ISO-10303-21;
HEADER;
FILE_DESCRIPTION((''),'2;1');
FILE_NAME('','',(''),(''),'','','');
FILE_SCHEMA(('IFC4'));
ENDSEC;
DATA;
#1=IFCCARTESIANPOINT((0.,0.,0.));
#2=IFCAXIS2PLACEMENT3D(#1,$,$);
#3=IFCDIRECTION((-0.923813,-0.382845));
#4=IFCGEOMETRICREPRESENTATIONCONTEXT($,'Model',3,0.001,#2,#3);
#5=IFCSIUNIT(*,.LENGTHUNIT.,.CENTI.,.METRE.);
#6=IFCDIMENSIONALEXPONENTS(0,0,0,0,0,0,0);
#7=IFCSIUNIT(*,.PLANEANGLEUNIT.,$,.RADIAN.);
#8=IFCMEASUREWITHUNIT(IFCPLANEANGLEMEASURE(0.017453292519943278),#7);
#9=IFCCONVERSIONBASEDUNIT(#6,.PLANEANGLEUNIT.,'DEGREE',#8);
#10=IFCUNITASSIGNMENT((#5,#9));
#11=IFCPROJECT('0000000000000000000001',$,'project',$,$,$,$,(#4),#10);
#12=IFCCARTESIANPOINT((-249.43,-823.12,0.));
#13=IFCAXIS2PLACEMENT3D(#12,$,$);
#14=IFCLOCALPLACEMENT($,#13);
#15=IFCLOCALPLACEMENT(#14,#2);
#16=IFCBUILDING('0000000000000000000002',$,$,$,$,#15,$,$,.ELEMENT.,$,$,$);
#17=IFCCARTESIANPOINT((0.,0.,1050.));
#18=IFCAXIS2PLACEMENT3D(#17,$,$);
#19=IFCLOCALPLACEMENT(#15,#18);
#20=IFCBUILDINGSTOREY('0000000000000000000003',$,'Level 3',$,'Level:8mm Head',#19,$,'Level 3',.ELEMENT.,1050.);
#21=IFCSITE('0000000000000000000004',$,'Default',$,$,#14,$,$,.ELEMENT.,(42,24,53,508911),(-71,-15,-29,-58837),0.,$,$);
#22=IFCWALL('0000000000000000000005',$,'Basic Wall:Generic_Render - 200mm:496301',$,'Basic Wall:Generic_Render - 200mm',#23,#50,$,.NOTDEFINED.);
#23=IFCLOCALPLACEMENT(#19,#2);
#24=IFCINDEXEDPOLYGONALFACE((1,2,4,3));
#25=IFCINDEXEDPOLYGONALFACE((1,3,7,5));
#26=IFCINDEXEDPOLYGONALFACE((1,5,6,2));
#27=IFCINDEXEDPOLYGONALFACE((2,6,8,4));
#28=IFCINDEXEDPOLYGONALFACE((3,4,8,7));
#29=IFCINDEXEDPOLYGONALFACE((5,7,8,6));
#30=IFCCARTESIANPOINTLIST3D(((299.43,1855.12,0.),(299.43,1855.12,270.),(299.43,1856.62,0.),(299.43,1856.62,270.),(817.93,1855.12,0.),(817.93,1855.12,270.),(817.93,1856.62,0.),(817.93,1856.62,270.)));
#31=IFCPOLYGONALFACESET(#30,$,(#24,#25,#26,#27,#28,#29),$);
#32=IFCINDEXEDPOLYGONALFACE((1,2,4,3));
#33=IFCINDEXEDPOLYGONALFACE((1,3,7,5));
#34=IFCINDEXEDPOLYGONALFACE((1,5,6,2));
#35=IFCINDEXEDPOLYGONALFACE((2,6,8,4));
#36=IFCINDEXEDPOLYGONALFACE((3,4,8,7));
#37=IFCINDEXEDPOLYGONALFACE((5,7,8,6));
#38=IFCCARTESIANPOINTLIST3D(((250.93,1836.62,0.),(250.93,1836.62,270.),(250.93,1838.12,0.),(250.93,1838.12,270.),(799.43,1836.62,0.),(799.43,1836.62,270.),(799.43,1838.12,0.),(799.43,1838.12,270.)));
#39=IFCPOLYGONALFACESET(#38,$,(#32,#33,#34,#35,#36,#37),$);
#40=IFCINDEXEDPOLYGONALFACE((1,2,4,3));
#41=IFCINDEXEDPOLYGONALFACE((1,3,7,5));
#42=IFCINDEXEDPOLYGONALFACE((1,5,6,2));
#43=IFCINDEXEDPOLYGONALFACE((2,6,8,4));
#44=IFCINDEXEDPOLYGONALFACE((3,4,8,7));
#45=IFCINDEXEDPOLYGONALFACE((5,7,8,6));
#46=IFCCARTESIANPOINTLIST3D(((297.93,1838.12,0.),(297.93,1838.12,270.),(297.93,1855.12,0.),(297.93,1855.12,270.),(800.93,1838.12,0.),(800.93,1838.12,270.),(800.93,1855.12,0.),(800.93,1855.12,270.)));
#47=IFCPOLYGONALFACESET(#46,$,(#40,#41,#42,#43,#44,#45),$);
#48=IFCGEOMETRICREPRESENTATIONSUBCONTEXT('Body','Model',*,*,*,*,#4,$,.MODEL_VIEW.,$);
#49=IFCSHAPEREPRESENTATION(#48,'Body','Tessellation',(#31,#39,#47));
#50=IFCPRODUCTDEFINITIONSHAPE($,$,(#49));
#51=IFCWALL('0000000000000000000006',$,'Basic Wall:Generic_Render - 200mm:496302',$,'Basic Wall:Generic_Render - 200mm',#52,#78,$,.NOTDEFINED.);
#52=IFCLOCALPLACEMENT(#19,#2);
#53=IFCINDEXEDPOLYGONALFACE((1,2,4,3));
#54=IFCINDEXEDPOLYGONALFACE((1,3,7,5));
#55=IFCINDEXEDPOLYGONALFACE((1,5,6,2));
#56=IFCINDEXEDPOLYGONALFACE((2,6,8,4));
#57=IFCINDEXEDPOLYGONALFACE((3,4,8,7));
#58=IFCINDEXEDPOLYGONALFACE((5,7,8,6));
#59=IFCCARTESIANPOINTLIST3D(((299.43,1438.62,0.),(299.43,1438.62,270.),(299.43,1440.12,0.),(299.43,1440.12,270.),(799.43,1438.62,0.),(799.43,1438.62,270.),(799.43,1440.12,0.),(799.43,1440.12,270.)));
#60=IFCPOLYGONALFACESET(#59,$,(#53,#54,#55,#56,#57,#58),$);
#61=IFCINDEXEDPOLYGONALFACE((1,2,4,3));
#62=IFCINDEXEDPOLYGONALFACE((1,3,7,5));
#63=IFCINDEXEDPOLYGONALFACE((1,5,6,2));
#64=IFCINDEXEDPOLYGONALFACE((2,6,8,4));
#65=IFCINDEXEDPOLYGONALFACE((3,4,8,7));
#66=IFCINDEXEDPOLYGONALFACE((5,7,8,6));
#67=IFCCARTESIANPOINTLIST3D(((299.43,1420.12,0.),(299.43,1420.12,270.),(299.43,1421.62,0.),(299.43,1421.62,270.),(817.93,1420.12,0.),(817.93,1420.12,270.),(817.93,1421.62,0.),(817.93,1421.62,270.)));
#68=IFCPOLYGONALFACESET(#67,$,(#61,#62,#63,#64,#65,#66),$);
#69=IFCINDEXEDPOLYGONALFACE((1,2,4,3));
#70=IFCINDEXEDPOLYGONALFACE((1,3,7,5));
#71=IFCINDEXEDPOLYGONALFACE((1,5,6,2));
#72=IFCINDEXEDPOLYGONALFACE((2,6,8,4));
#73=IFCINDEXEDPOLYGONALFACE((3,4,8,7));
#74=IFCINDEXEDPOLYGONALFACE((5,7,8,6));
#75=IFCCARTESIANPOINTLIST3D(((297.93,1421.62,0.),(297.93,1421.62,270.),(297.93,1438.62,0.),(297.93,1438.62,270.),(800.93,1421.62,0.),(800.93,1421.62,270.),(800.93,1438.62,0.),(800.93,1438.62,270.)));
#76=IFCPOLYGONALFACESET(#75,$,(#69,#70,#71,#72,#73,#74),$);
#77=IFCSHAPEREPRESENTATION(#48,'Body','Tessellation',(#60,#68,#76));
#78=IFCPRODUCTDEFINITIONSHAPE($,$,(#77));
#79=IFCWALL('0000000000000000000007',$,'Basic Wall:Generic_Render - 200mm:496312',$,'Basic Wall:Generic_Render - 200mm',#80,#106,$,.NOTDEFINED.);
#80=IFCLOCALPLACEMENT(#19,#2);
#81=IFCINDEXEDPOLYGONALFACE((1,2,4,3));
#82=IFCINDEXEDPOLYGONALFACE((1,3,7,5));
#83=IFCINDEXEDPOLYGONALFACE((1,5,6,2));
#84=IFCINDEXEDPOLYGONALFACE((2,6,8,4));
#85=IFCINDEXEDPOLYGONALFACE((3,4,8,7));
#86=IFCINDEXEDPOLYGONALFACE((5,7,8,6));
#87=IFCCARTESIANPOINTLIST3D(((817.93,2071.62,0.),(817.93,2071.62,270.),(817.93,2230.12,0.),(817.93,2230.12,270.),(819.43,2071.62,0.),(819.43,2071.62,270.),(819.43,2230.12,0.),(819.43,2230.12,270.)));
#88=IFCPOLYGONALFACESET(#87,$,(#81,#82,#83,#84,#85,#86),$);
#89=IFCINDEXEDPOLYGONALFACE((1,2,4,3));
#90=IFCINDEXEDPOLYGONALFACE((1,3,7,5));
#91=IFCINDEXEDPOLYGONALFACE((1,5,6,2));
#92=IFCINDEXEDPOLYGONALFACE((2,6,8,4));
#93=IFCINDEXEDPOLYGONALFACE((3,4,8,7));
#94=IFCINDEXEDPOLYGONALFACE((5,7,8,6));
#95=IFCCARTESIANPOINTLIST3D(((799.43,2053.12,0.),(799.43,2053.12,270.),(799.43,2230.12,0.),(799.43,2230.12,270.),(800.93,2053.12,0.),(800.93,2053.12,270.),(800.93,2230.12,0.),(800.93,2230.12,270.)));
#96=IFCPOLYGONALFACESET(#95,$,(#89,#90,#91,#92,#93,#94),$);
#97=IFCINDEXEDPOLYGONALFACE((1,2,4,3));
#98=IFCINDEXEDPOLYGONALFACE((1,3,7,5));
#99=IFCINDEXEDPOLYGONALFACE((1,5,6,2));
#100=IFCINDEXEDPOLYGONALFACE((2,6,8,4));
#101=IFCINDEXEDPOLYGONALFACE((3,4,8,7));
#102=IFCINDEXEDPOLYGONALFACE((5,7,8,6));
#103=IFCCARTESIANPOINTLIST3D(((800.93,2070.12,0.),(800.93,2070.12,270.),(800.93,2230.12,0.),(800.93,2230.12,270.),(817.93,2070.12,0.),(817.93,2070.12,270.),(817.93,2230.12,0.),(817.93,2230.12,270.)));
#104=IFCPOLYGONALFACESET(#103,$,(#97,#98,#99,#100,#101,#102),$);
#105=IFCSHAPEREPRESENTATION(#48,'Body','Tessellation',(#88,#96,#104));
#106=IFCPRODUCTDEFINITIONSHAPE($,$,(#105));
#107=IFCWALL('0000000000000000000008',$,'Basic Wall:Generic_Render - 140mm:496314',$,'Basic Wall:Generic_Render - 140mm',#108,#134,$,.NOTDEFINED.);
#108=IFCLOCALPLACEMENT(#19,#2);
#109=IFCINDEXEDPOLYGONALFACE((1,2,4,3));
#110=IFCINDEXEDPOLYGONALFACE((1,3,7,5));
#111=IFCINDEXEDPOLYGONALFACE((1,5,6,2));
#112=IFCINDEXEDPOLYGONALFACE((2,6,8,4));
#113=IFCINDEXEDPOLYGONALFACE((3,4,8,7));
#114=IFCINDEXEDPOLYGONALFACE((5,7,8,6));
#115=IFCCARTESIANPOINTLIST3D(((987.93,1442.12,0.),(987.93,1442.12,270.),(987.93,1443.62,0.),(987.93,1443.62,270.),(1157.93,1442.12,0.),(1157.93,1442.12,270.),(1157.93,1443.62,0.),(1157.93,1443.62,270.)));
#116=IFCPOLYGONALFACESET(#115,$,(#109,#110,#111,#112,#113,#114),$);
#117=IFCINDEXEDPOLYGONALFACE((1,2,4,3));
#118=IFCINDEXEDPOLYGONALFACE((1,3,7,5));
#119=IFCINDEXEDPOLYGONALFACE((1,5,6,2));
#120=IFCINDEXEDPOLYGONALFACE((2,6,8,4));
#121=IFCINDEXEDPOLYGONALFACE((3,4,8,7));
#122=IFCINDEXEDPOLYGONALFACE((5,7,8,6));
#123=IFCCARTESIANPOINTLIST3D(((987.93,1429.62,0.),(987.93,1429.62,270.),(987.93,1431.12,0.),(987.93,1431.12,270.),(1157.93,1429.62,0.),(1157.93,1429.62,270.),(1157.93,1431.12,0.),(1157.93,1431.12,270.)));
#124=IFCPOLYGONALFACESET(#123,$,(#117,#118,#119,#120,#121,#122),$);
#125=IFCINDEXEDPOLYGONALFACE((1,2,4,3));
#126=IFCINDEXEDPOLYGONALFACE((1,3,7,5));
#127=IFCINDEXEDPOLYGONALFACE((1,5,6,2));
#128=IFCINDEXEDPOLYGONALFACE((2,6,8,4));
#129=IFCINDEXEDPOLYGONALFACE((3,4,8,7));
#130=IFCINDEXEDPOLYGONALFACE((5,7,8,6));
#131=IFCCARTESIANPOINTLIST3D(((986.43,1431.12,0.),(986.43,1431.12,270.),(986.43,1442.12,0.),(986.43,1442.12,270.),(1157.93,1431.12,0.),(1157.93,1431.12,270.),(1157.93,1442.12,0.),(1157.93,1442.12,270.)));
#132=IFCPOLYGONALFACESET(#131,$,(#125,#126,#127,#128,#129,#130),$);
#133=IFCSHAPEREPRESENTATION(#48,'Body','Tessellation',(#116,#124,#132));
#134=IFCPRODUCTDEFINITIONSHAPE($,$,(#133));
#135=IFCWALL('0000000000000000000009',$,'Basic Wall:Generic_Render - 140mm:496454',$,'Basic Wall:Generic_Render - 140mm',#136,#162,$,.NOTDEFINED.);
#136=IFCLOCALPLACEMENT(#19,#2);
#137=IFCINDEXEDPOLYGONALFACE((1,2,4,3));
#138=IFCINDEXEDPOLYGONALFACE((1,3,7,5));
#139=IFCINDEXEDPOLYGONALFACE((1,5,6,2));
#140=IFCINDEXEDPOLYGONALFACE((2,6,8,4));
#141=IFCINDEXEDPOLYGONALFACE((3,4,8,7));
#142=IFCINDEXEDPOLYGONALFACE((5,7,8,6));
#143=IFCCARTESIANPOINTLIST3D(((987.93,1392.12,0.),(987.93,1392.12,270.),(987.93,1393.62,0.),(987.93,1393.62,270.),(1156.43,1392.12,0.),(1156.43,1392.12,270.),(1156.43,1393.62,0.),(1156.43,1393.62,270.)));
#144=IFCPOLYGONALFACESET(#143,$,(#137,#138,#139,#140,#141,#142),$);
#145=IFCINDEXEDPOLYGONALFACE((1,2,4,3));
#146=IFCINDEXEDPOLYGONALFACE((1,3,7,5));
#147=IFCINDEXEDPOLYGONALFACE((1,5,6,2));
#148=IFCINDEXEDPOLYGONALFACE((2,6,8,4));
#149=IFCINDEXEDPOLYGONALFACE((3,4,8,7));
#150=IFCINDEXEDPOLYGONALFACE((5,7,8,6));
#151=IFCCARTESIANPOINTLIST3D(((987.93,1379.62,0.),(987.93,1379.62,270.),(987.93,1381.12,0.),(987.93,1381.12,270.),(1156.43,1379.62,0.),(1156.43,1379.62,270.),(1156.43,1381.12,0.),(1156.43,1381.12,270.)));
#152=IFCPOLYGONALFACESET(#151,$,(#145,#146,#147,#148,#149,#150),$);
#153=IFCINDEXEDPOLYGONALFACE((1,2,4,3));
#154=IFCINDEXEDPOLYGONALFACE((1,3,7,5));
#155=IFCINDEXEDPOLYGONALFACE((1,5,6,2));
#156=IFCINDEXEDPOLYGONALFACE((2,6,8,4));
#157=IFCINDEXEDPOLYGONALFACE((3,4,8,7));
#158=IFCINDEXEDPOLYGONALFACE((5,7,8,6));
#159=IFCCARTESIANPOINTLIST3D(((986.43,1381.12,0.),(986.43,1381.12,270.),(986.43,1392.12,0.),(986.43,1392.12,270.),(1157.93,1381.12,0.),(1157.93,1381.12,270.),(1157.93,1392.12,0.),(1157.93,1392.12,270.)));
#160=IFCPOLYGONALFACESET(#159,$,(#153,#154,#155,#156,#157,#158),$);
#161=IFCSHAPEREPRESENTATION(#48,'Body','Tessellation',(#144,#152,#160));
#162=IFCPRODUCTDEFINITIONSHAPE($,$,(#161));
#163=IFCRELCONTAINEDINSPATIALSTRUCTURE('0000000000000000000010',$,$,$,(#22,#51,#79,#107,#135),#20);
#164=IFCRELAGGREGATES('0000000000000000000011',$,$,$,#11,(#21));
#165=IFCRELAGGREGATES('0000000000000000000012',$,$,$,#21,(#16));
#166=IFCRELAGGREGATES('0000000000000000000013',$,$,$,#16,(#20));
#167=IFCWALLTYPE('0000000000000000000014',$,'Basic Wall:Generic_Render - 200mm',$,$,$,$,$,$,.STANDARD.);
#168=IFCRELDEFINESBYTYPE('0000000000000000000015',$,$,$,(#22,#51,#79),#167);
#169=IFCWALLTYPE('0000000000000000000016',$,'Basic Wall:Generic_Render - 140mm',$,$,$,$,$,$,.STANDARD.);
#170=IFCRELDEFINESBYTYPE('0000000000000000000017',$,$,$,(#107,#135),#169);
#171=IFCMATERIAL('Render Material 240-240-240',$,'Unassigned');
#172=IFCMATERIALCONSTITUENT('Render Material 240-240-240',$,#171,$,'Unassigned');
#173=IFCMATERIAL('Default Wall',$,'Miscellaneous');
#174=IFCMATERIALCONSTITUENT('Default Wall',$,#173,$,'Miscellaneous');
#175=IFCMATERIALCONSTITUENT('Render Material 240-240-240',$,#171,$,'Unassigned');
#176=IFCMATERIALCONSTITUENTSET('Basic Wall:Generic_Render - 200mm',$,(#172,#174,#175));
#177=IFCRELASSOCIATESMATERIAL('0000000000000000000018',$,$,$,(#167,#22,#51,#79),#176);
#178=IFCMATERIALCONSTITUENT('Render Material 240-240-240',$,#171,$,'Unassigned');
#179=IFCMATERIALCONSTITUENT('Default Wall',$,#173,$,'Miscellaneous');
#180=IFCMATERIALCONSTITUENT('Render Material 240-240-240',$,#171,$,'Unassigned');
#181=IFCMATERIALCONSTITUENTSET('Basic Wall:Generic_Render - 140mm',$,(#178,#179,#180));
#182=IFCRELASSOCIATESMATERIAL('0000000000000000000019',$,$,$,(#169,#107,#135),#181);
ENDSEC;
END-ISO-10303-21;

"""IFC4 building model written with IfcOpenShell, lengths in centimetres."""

from ifc_helpers import new_model, entity, si_unit, converted_unit, direction, frame, origin, place, context, subcontext, project, spatial, indexed_curve, outline, extrude, material, constituent, constituent_set, type_object, element, save


model = new_model("IFC4")

# Units and contexts
model_context = context("Model", 3, precision=0.001, world=origin(), true_north=direction((-0.923813, -0.382845)))
body_context = subcontext(model_context, "Body", "Model", "MODEL_VIEW")
ifc_project = project(units=[si_unit("LENGTHUNIT", "METRE", prefix="CENTI"), converted_unit("PLANEANGLEUNIT", "DEGREE", entity("IfcPlaneAngleMeasure", 0.017453292519943278), si_unit("PLANEANGLEUNIT", "RADIAN"), dimensions=[0, 0, 0, 0, 0, 0, 0])], contexts=[model_context])

# Site, building, storey
site_placement = place(None, frame((-249.43, -823.12, 0.0)))
site = spatial("IfcSite", under=ifc_project, at=site_placement, Name="Default", CompositionType="ELEMENT", RefLatitude=(42, 24, 53, 508911), RefLongitude=(-71, -15, -29, -58837), RefElevation=0.0)
building_placement = place(site_placement, origin())
building = spatial("IfcBuilding", under=site, at=building_placement, CompositionType="ELEMENT")
storey_placement = place(building_placement, frame((0.0, 0.0, 1050.0)))
storey = spatial("IfcBuildingStorey", under=building, at=storey_placement, Name="Level 3", ObjectType="Level:8mm Head", LongName="Level 3", CompositionType="ELEMENT", Elevation=1050.0)

# Shared definitions
ifc_material_1 = material(Name="Render Material 240-240-240", Category="Unassigned")

# Shared definitions
ifc_constituent_1 = constituent(ifc_material_1, Name="Render Material 240-240-240", Category="Unassigned")
ifc_material_2 = material(Name="Default Wall", Category="Miscellaneous")
ifc_constituent_2 = constituent(ifc_material_2, Name="Default Wall", Category="Miscellaneous")
ifc_constituent_3 = constituent(ifc_material_1, Name="Render Material 240-240-240", Category="Unassigned")
ifc_constituent_set_1 = constituent_set(constituents=[ifc_constituent_1, ifc_constituent_2, ifc_constituent_3], Name="Basic Wall:Generic_Render - 200mm")
wall_type_1 = type_object("IfcWallType", Name="Basic Wall:Generic_Render - 200mm", PredefinedType="STANDARD", material=ifc_constituent_set_1)

# Walls
wall_1_placement = place(storey_placement, frame((799.43, 1846.62, 0.0), z_axis=(0.0, 0.0, 1.0), x_axis=(-1.0, 0.0, 0.0)))
element("IfcWall", 1, at=wall_1_placement, inside=storey, type_object=wall_type_1, material=ifc_constituent_set_1, Name="Basic Wall:Generic_Render - 200mm:496301", ObjectType="Basic Wall:Generic_Render - 200mm", PredefinedType="NOTDEFINED", context=body_context, shape_type="SweptSolid", body=[
    extrude(outline(indexed_curve([(-0.75, -259.25), (0.75, -259.25), (0.75, 259.25), (-0.75, 259.25), (-0.75, -259.25)], self_intersect=False)), frame((240.75, -9.25, 0.0), z_axis=(0.0, 0.0, 1.0), x_axis=(0.0, 1.0, 0.0)), (0.0, 0.0, 1.0), 270.0),
    extrude(outline(indexed_curve([(-0.75, -274.25), (0.75, -274.25), (0.75, 274.25), (-0.75, 274.25), (-0.75, -274.25)], self_intersect=False)), frame((274.25, 9.25, 0.0), z_axis=(0.0, 0.0, 1.0), x_axis=(0.0, -1.0, 0.0)), (0.0, 0.0, 1.0), 270.0),
    extrude(outline(indexed_curve([(-251.5, -8.5), (251.5, -8.5), (251.5, 8.5), (-251.5, 8.5), (-251.5, -8.5)], self_intersect=False)), frame((250.0, 0.0, 0.0)), (0.0, 0.0, 1.0), 270.0),
])
wall_2_placement = place(storey_placement, frame((799.43, 1430.12, 0.0), z_axis=(0.0, 0.0, 1.0), x_axis=(-1.0, 0.0, 0.0)))
element("IfcWall", 2, at=wall_2_placement, inside=storey, type_object=wall_type_1, material=ifc_constituent_set_1, Name="Basic Wall:Generic_Render - 200mm:496302", ObjectType="Basic Wall:Generic_Render - 200mm", PredefinedType="NOTDEFINED", context=body_context, shape_type="SweptSolid", body=[
    extrude(outline(indexed_curve([(-0.75, -250.0), (0.75, -250.0), (0.75, 250.0), (-0.75, 250.0), (-0.75, -250.0)], self_intersect=False)), frame((250.0, -9.25, 0.0), z_axis=(0.0, 0.0, 1.0), x_axis=(0.0, 1.0, 0.0)), (0.0, 0.0, 1.0), 270.0),
    extrude(outline(indexed_curve([(-0.75, -259.25), (0.75, -259.25), (0.75, 259.25), (-0.75, 259.25), (-0.75, -259.25)], self_intersect=False)), frame((240.75, 9.25, 0.0), z_axis=(0.0, 0.0, 1.0), x_axis=(0.0, -1.0, 0.0)), (0.0, 0.0, 1.0), 270.0),
    extrude(outline(indexed_curve([(-251.5, -8.5), (251.5, -8.5), (251.5, 8.5), (-251.5, 8.5), (-251.5, -8.5)], self_intersect=False)), frame((250.0, 0.0, 0.0)), (0.0, 0.0, 1.0), 270.0),
])

# Walls
wall_3_placement = place(storey_placement, frame((809.43, 2071.62, 0.0), z_axis=(0.0, 0.0, 1.0), x_axis=(0.0, 1.0, 0.0)))
element("IfcWall", 3, at=wall_3_placement, inside=storey, type_object=wall_type_1, material=ifc_constituent_set_1, Name="Basic Wall:Generic_Render - 200mm:496312", ObjectType="Basic Wall:Generic_Render - 200mm", PredefinedType="NOTDEFINED", context=body_context, shape_type="SweptSolid", body=[
    extrude(outline(indexed_curve([(-0.75, -79.25), (0.75, -79.25), (0.75, 79.25), (-0.75, 79.25), (-0.75, -79.25)], self_intersect=False)), frame((79.25, -9.25, 0.0), z_axis=(0.0, 0.0, 1.0), x_axis=(0.0, 1.0, 0.0)), (0.0, 0.0, 1.0), 270.0),
    extrude(outline(indexed_curve([(-0.75, -88.5), (0.75, -88.5), (0.75, 88.5), (-0.75, 88.5), (-0.75, -88.5)], self_intersect=False)), frame((70.0, 9.25, 0.0), z_axis=(0.0, 0.0, 1.0), x_axis=(0.0, -1.0, 0.0)), (0.0, 0.0, 1.0), 270.0),
    extrude(outline(indexed_curve([(-80.0, -8.5), (80.0, -8.5), (80.0, 8.5), (-80.0, 8.5), (-80.0, -8.5)], self_intersect=False)), frame((78.5, 0.0, 0.0)), (0.0, 0.0, 1.0), 270.0),
])
ifc_constituent_4 = constituent(ifc_material_1, Name="Render Material 240-240-240", Category="Unassigned")
ifc_constituent_5 = constituent(ifc_material_2, Name="Default Wall", Category="Miscellaneous")
ifc_constituent_6 = constituent(ifc_material_1, Name="Render Material 240-240-240", Category="Unassigned")
ifc_constituent_set_2 = constituent_set(constituents=[ifc_constituent_4, ifc_constituent_5, ifc_constituent_6], Name="Basic Wall:Generic_Render - 140mm")
wall_type_2 = type_object("IfcWallType", Name="Basic Wall:Generic_Render - 140mm", PredefinedType="STANDARD", material=ifc_constituent_set_2)
wall_4_placement = place(storey_placement, frame((1157.93, 1436.62, 0.0), z_axis=(0.0, 0.0, 1.0), x_axis=(-1.0, 0.0, 0.0)))
element("IfcWall", 4, at=wall_4_placement, inside=storey, type_object=wall_type_2, material=ifc_constituent_set_2, Name="Basic Wall:Generic_Render - 140mm:496314", ObjectType="Basic Wall:Generic_Render - 140mm", PredefinedType="NOTDEFINED", context=body_context, shape_type="SweptSolid", body=[
    extrude(outline(indexed_curve([(-0.75, -85.0), (0.75, -85.0), (0.75, 85.0), (-0.75, 85.0), (-0.75, -85.0)], self_intersect=False)), frame((85.0, -6.25, 0.0), z_axis=(0.0, 0.0, 1.0), x_axis=(0.0, 1.0, 0.0)), (0.0, 0.0, 1.0), 270.0),
    extrude(outline(indexed_curve([(-0.75, -85.0), (0.75, -85.0), (0.75, 85.0), (-0.75, 85.0), (-0.75, -85.0)], self_intersect=False)), frame((85.0, 6.25, 0.0), z_axis=(0.0, 0.0, 1.0), x_axis=(0.0, -1.0, 0.0)), (0.0, 0.0, 1.0), 270.0),
    extrude(outline(indexed_curve([(-85.75, -5.5), (85.75, -5.5), (85.75, 5.5), (-85.75, 5.5), (-85.75, -5.5)], self_intersect=False)), frame((85.75, 0.0, 0.0)), (0.0, 0.0, 1.0), 270.0),
])
wall_5_placement = place(storey_placement, frame((1156.43, 1386.62, 0.0), z_axis=(0.0, 0.0, 1.0), x_axis=(-1.0, 0.0, 0.0)))
element("IfcWall", 5, at=wall_5_placement, inside=storey, type_object=wall_type_2, material=ifc_constituent_set_2, Name="Basic Wall:Generic_Render - 140mm:496454", ObjectType="Basic Wall:Generic_Render - 140mm", PredefinedType="NOTDEFINED", context=body_context, shape_type="SweptSolid", body=[
    extrude(outline(indexed_curve([(-0.75, -84.25), (0.75, -84.25), (0.75, 84.25), (-0.75, 84.25), (-0.75, -84.25)], self_intersect=False)), frame((84.25, -6.25, 0.0), z_axis=(0.0, 0.0, 1.0), x_axis=(0.0, 1.0, 0.0)), (0.0, 0.0, 1.0), 270.0),
    extrude(outline(indexed_curve([(-0.75, -84.25), (0.75, -84.25), (0.75, 84.25), (-0.75, 84.25), (-0.75, -84.25)], self_intersect=False)), frame((84.25, 6.25, 0.0), z_axis=(0.0, 0.0, 1.0), x_axis=(0.0, -1.0, 0.0)), (0.0, 0.0, 1.0), 270.0),
    extrude(outline(indexed_curve([(-85.75, -5.5), (85.75, -5.5), (85.75, 5.5), (-85.75, 5.5), (-85.75, -5.5)], self_intersect=False)), frame((84.25, 0.0, 0.0)), (0.0, 0.0, 1.0), 270.0),
])

save(model, "model.ifc")
